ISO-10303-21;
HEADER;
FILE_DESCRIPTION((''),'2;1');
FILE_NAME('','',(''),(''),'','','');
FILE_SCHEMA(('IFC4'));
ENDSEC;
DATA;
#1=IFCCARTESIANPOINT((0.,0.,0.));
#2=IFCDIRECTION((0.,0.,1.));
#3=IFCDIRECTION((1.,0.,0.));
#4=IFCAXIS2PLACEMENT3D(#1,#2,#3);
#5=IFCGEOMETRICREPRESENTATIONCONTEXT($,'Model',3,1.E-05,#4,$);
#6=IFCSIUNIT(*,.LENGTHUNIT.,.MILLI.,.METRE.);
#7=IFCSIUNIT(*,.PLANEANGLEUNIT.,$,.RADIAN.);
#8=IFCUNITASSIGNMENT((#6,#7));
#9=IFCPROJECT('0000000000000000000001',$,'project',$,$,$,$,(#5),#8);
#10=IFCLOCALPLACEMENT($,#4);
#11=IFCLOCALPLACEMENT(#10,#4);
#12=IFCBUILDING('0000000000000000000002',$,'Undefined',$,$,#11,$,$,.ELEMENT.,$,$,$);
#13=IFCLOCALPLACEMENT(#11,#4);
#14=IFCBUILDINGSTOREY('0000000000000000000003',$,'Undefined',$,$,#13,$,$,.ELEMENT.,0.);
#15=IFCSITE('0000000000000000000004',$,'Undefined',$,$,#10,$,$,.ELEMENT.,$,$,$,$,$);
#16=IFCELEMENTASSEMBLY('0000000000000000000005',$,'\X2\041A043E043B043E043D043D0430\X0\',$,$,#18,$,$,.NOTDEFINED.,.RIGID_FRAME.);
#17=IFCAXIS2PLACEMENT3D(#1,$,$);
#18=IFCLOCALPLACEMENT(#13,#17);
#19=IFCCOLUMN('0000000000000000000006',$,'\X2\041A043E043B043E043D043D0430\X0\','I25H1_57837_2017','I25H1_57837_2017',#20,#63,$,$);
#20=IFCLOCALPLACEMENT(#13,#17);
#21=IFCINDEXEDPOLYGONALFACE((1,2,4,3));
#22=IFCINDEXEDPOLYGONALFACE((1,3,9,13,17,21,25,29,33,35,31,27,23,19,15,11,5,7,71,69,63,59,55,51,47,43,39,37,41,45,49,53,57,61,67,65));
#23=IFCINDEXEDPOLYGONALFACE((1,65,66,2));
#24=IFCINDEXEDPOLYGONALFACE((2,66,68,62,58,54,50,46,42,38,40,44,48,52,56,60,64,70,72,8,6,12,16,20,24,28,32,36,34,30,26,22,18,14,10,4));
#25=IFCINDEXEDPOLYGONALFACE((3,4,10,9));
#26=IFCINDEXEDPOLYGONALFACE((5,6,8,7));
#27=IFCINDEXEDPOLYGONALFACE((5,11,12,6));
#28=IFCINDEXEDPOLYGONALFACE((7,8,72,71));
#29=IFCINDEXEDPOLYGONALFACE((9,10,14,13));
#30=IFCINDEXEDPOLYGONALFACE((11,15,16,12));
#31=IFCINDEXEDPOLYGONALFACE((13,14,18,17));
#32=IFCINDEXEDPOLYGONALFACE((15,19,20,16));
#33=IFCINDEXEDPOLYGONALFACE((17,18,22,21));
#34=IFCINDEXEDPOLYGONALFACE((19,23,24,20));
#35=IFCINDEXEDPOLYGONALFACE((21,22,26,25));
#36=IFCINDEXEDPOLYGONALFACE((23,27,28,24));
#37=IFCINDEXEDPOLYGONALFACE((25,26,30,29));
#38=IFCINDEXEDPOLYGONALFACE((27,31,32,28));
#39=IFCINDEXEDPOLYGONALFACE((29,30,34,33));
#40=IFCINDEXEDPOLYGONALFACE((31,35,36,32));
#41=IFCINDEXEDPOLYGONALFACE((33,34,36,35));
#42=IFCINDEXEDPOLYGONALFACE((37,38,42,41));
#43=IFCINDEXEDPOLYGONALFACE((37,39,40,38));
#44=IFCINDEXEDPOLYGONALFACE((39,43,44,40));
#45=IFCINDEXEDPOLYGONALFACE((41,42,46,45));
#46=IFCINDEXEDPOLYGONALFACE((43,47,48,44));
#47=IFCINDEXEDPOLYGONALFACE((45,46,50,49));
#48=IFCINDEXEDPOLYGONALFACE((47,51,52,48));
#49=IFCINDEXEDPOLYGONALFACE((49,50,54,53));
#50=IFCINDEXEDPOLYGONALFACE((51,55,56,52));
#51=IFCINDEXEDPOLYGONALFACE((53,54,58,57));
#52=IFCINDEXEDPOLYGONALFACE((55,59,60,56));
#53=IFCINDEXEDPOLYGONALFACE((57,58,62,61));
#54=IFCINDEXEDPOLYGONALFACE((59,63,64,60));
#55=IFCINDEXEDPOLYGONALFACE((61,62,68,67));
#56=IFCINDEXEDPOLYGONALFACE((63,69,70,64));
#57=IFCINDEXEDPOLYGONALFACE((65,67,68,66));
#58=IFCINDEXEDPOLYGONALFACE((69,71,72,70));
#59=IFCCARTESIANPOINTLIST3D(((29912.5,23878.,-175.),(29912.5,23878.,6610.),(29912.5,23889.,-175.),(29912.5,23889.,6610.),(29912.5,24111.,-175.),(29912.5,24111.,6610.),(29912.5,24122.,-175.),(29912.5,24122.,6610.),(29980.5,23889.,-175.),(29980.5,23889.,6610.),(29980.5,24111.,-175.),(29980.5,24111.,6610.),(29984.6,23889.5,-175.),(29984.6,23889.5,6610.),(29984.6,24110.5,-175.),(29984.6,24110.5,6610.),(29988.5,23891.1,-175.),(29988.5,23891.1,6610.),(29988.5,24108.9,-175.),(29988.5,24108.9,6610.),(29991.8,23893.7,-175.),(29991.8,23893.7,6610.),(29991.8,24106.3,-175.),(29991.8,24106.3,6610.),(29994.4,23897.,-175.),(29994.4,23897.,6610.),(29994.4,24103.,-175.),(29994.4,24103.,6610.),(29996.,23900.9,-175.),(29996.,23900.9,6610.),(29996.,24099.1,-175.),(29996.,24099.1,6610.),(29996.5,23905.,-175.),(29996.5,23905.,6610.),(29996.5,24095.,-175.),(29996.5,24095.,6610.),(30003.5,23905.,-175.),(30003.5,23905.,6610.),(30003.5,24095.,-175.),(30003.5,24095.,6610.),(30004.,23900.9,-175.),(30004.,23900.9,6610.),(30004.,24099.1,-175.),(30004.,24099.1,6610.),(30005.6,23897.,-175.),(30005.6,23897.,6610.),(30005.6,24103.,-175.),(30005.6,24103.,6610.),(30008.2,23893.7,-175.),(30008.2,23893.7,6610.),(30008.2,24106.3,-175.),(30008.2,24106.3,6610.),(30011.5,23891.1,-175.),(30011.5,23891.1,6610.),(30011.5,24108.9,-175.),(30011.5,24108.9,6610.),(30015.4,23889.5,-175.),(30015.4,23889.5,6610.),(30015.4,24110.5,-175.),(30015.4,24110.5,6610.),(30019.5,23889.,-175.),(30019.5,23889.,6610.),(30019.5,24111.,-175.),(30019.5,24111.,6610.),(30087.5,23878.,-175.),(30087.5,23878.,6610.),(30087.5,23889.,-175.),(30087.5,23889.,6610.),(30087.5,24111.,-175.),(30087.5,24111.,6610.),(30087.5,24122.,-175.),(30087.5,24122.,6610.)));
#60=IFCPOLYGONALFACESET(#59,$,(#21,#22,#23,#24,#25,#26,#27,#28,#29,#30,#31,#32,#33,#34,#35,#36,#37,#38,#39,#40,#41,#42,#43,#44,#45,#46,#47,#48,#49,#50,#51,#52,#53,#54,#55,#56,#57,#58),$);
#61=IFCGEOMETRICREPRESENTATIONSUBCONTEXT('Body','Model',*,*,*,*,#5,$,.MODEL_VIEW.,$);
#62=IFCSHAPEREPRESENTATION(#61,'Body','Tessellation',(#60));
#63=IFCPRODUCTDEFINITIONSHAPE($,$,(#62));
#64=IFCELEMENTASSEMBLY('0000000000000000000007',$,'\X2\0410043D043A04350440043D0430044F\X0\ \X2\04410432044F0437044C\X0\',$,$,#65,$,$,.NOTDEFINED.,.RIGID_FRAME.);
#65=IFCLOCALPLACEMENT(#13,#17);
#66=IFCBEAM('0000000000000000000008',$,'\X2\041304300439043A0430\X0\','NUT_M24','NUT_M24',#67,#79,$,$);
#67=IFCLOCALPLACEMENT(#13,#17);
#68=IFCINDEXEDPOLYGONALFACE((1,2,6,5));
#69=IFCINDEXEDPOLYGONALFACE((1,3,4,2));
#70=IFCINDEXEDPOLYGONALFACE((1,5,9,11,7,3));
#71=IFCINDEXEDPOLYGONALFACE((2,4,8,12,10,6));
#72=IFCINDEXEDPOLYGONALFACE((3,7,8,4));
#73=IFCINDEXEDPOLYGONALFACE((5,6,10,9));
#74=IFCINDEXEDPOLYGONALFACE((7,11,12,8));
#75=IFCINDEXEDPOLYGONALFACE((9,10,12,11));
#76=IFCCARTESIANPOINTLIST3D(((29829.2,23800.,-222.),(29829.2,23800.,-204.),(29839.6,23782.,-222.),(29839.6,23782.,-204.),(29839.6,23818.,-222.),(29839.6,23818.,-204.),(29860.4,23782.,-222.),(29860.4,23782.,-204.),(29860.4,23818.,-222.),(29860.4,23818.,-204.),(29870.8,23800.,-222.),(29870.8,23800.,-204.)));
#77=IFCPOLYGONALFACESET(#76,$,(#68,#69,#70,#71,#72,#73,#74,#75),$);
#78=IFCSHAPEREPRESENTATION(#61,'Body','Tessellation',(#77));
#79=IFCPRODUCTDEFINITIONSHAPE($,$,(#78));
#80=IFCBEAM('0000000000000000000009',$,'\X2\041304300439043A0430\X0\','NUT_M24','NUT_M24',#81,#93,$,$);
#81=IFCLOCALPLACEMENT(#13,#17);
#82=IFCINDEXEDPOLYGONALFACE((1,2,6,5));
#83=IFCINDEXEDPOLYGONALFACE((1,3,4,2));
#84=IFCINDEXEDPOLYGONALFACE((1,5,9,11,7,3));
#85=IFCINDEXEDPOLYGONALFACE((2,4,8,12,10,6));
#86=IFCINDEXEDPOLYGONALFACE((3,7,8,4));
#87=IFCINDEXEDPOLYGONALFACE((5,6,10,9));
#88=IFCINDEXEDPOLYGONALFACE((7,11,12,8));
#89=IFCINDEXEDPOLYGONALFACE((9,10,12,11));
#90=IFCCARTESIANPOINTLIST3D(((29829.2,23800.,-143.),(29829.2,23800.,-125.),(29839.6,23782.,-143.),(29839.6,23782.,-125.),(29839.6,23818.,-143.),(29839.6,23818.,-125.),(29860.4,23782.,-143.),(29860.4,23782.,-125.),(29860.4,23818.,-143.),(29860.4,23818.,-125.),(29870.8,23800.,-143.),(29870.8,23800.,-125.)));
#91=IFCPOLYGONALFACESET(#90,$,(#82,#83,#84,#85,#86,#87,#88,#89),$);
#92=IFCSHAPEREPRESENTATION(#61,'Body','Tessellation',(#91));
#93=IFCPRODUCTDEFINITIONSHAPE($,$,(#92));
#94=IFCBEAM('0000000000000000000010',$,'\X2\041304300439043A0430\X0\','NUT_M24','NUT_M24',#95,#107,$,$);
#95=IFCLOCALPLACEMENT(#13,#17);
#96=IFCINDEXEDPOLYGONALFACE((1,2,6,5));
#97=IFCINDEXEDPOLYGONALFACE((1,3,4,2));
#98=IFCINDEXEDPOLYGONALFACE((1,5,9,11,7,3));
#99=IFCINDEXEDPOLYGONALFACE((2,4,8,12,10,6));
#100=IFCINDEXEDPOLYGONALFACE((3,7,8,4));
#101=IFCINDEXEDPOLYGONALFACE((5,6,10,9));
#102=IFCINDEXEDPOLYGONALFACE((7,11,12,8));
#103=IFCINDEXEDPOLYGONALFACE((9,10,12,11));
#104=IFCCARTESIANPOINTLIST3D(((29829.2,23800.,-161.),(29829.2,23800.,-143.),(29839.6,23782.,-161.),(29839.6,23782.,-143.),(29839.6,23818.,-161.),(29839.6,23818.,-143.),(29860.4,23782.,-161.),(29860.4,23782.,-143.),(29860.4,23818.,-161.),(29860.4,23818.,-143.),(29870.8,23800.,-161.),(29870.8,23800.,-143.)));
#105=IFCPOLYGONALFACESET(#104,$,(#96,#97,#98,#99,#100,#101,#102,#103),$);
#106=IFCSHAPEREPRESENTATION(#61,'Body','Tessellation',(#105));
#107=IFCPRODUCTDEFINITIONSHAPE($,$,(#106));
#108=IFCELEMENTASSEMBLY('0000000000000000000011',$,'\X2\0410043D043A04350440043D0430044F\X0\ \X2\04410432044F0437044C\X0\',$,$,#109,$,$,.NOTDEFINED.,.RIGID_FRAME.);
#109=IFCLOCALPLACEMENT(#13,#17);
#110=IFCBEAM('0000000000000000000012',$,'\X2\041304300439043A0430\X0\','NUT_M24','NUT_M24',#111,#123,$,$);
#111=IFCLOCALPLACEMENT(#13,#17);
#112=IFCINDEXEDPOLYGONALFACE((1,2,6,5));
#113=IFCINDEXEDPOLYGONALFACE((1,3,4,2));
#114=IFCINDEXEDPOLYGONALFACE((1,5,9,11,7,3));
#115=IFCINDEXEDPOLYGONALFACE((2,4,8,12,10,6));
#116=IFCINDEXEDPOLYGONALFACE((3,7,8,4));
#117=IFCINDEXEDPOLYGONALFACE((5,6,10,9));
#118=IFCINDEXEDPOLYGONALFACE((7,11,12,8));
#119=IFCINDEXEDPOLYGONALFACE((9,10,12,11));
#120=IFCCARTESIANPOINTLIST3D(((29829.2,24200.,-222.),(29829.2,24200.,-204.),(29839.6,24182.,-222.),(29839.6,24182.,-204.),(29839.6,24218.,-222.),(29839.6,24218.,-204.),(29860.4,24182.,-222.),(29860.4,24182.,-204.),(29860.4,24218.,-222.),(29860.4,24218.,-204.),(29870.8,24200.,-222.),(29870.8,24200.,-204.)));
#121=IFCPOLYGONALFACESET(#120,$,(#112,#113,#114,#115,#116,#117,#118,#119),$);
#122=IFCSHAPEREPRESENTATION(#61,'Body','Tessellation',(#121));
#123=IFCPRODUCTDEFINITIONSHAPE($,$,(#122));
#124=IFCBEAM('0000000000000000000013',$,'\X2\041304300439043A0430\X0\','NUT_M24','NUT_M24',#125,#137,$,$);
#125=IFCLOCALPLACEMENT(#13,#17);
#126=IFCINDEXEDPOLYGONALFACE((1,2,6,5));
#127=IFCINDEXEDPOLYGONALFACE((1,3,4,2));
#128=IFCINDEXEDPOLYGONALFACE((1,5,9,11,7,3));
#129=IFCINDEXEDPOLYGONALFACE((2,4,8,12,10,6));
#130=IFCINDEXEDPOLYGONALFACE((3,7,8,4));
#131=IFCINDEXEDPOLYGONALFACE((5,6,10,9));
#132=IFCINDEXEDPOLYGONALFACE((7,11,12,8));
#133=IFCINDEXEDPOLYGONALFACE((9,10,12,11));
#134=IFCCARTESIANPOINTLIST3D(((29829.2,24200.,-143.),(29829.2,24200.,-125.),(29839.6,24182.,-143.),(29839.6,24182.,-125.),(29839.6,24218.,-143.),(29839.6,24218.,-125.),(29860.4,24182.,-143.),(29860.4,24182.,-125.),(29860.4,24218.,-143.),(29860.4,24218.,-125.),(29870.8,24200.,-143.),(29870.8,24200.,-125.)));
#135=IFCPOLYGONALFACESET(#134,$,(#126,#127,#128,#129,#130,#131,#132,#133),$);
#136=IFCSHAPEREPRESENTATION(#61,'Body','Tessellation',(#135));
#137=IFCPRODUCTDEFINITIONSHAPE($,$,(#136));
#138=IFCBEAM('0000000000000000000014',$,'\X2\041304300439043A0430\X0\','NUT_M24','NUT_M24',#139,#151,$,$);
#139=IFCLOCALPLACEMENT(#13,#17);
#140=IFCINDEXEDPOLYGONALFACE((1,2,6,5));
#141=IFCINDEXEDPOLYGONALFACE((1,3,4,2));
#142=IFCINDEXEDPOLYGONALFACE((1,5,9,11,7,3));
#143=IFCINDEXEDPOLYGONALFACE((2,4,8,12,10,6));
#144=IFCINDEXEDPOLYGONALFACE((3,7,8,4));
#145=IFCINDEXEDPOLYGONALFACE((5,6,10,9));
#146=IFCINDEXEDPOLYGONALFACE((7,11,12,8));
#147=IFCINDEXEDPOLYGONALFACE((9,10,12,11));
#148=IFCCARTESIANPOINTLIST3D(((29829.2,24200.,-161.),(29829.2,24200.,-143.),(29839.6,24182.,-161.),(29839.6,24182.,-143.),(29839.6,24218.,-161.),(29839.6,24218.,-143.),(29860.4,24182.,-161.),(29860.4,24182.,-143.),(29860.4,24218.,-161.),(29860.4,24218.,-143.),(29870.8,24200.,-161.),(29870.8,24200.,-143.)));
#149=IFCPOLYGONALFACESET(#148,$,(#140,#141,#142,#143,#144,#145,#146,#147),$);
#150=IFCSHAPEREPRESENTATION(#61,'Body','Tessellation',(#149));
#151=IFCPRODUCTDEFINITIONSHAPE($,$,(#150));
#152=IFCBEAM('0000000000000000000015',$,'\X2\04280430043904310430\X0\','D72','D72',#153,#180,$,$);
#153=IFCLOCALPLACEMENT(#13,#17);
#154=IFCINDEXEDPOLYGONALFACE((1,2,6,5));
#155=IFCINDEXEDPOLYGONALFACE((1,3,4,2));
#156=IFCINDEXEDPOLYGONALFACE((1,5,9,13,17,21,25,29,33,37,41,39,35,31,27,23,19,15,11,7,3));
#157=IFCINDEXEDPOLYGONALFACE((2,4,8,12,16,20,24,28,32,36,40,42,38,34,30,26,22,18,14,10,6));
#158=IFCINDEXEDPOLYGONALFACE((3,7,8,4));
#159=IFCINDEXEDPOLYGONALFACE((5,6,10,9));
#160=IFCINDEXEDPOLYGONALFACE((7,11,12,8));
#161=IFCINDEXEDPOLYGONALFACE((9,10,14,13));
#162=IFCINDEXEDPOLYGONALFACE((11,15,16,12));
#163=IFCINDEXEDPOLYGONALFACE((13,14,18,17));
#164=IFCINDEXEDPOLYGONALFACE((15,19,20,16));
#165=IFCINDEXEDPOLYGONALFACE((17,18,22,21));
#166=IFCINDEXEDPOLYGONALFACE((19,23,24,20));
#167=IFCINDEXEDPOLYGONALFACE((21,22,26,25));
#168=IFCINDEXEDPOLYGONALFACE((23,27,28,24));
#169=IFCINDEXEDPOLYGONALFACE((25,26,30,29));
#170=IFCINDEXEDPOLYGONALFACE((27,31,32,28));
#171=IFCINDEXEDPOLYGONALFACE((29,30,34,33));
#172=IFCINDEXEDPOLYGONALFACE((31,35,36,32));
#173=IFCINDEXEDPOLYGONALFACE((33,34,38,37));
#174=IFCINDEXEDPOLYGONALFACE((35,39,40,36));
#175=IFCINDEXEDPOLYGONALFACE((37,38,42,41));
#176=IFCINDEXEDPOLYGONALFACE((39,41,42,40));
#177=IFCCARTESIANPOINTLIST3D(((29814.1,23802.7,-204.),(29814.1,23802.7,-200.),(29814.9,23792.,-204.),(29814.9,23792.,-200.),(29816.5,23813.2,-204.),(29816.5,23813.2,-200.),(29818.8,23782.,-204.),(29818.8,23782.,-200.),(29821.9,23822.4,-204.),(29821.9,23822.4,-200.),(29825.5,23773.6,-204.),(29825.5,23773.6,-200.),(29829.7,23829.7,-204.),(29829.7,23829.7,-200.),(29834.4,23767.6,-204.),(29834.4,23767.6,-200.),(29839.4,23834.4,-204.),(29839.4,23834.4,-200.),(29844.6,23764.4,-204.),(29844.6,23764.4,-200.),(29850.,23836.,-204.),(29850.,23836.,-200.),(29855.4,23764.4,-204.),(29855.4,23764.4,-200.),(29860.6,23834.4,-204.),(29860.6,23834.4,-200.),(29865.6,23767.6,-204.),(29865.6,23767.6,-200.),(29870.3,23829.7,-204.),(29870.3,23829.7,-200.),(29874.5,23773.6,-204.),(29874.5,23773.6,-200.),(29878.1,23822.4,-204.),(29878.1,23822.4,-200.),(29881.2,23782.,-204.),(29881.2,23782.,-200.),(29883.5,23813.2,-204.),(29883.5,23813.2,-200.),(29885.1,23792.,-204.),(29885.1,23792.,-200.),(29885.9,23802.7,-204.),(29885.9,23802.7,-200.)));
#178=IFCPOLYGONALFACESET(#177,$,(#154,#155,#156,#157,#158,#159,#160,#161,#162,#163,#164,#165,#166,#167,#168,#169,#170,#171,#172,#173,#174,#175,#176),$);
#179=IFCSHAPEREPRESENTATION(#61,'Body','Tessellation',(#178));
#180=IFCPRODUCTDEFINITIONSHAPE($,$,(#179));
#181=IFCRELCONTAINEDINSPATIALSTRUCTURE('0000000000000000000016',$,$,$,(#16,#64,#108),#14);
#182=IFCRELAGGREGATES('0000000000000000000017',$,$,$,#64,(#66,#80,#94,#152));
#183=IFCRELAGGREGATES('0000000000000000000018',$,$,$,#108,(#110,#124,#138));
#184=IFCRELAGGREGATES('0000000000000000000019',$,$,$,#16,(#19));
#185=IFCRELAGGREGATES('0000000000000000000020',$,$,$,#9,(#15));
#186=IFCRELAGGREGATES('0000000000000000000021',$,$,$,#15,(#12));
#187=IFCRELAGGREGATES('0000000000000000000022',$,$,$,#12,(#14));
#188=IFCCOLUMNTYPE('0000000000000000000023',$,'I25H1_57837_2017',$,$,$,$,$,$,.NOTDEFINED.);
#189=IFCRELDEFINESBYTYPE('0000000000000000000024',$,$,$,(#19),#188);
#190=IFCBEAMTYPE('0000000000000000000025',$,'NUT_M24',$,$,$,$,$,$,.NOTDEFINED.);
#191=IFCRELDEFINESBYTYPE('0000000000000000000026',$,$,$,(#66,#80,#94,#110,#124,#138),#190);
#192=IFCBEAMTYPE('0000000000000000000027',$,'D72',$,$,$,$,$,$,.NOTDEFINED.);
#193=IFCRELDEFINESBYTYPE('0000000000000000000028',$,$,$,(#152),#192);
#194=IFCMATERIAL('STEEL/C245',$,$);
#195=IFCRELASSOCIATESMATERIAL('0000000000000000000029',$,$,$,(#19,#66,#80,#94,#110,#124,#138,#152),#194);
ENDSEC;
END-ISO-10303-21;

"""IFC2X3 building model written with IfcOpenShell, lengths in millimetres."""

from ifc_helpers import new_model, si_unit, frame, origin_with_axes, origin_2d_with_axis, place, context, subcontext, project, spatial, polyline, circle, i_section, outline, extrude, clip, halfspace, material, type_object, element, aggregate, save


model = new_model("IFC2X3")

# Units and contexts
model_context = context("Model", 3, precision=1e-05, world=origin_with_axes())
body_context = subcontext(model_context, "Body", "Model", "MODEL_VIEW")
ifc_project = project(units=[si_unit("LENGTHUNIT", "METRE", prefix="MILLI"), si_unit("PLANEANGLEUNIT", "RADIAN")], contexts=[model_context])

# Site, building, storey
site_placement = place(None, origin_with_axes())
site = spatial("IfcSite", under=ifc_project, at=site_placement, Name="Undefined", CompositionType="ELEMENT")
building_placement = place(site_placement, origin_with_axes())
building = spatial("IfcBuilding", under=site, at=building_placement, Name="Undefined", CompositionType="ELEMENT")
storey_placement = place(building_placement, origin_with_axes())
storey = spatial("IfcBuildingStorey", under=building, at=storey_placement, Name="Undefined", CompositionType="ELEMENT", Elevation=0.0)

# Element assembly, column
ifc_material_1 = material(Name="STEEL/C245")
assembly_1_placement = place(storey_placement, origin_with_axes())
assembly_1 = element("IfcElementAssembly", 1, at=assembly_1_placement, inside=storey, Name="Колонна", AssemblyPlace="NOTDEFINED", PredefinedType="RIGID_FRAME")
column_type_1 = type_object("IfcColumnType", Name="I25H1_57837_2017", PredefinedType="NOTDEFINED")
column_1_placement = place(assembly_1_placement, frame((30000.0, 24000.0, 0.0), z_axis=(0.0, 0.0, 1.0), x_axis=(0.0, 1.0, 0.0)))
column_1 = element("IfcColumn", 2, at=column_1_placement, type_object=column_type_1, material=ifc_material_1, Name="Колонна", Description="I25H1_57837_2017", ObjectType="I25H1_57837_2017", context=body_context, shape_type="Clipping", body=[
    clip(extrude(i_section(OverallWidth=175.0, OverallDepth=244.0, WebThickness=7.0, FlangeThickness=11.0, FilletRadius=16.0, at=origin_2d_with_axis()), frame((0.0, 0.0, 6610.0), z_axis=(0.0, 0.0, -1.0), x_axis=(0.0, 1.0, 0.0)), (0.0, 0.0, 1.0), 6785.0), halfspace(frame((-122.0, 0.0, -175.0), z_axis=(0.0, 0.0, 1.0), x_axis=(0.0, 1.0, 0.0)), True)),
])

# Element assemblies, beams
assembly_2_placement = place(storey_placement, origin_with_axes())
assembly_2 = element("IfcElementAssembly", 3, at=assembly_2_placement, inside=storey, Name="Анкерная связь", AssemblyPlace="NOTDEFINED", PredefinedType="RIGID_FRAME")
beam_type_1 = type_object("IfcBeamType", Name="NUT_M24", PredefinedType="NOTDEFINED")
beam_1_placement = place(assembly_2_placement, frame((29850.0, 23800.0, -204.0), z_axis=(0.0, -1.0, 0.0), x_axis=(0.0, 0.0, -1.0)))
beam_1 = element("IfcBeam", 4, at=beam_1_placement, type_object=beam_type_1, material=ifc_material_1, Name="Гайка", Description="NUT_M24", ObjectType="NUT_M24", context=body_context, shape_type="SweptSolid", body=[
    extrude(outline(polyline([(-10.4, 18.0), (10.4, 18.0), (20.8, 0.0), (10.4, -18.0), (-10.4, -18.0), (-20.8, 0.0), (-10.4, 18.0)])), frame((18.0, 0.0, 0.0), z_axis=(-1.0, 0.0, 0.0), x_axis=(0.0, -1.0, 0.0)), (0.0, 0.0, 1.0), 18.0),
])
beam_2_placement = place(assembly_2_placement, frame((29850.0, 23800.0, -125.0), z_axis=(0.0, -1.0, 0.0), x_axis=(0.0, 0.0, -1.0)))
beam_2 = element("IfcBeam", 5, at=beam_2_placement, type_object=beam_type_1, material=ifc_material_1, Name="Гайка", Description="NUT_M24", ObjectType="NUT_M24", context=body_context, shape_type="SweptSolid", body=[
    extrude(outline(polyline([(-10.4, 18.0), (10.4, 18.0), (20.8, 0.0), (10.4, -18.0), (-10.4, -18.0), (-20.8, 0.0), (-10.4, 18.0)])), frame((18.0, 0.0, 0.0), z_axis=(-1.0, 0.0, 0.0), x_axis=(0.0, -1.0, 0.0)), (0.0, 0.0, 1.0), 18.0),
])
beam_3_placement = place(assembly_2_placement, frame((29850.0, 23800.0, -143.0), z_axis=(0.0, -1.0, 0.0), x_axis=(0.0, 0.0, -1.0)))
beam_3 = element("IfcBeam", 6, at=beam_3_placement, type_object=beam_type_1, material=ifc_material_1, Name="Гайка", Description="NUT_M24", ObjectType="NUT_M24", context=body_context, shape_type="SweptSolid", body=[
    extrude(outline(polyline([(-10.4, 18.0), (10.4, 18.0), (20.8, 0.0), (10.4, -18.0), (-10.4, -18.0), (-20.8, 0.0), (-10.4, 18.0)])), frame((18.0, 0.0, 0.0), z_axis=(-1.0, 0.0, 0.0), x_axis=(0.0, -1.0, 0.0)), (0.0, 0.0, 1.0), 18.0),
])
assembly_3_placement = place(storey_placement, origin_with_axes())
assembly_3 = element("IfcElementAssembly", 7, at=assembly_3_placement, inside=storey, Name="Анкерная связь", AssemblyPlace="NOTDEFINED", PredefinedType="RIGID_FRAME")
beam_4_placement = place(assembly_3_placement, frame((29850.0, 24200.0, -204.0), z_axis=(0.0, -1.0, 0.0), x_axis=(0.0, 0.0, -1.0)))
beam_4 = element("IfcBeam", 8, at=beam_4_placement, type_object=beam_type_1, material=ifc_material_1, Name="Гайка", Description="NUT_M24", ObjectType="NUT_M24", context=body_context, shape_type="SweptSolid", body=[
    extrude(outline(polyline([(-10.4, 18.0), (10.4, 18.0), (20.8, 0.0), (10.4, -18.0), (-10.4, -18.0), (-20.8, 0.0), (-10.4, 18.0)])), frame((18.0, 0.0, 0.0), z_axis=(-1.0, 0.0, 0.0), x_axis=(0.0, -1.0, 0.0)), (0.0, 0.0, 1.0), 18.0),
])
beam_5_placement = place(assembly_3_placement, frame((29850.0, 24200.0, -125.0), z_axis=(0.0, -1.0, 0.0), x_axis=(0.0, 0.0, -1.0)))
beam_5 = element("IfcBeam", 9, at=beam_5_placement, type_object=beam_type_1, material=ifc_material_1, Name="Гайка", Description="NUT_M24", ObjectType="NUT_M24", context=body_context, shape_type="SweptSolid", body=[
    extrude(outline(polyline([(-10.4, 18.0), (10.4, 18.0), (20.8, 0.0), (10.4, -18.0), (-10.4, -18.0), (-20.8, 0.0), (-10.4, 18.0)])), frame((18.0, 0.0, 0.0), z_axis=(-1.0, 0.0, 0.0), x_axis=(0.0, -1.0, 0.0)), (0.0, 0.0, 1.0), 18.0),
])
beam_6_placement = place(assembly_3_placement, frame((29850.0, 24200.0, -143.0), z_axis=(0.0, -1.0, 0.0), x_axis=(0.0, 0.0, -1.0)))
beam_6 = element("IfcBeam", 10, at=beam_6_placement, type_object=beam_type_1, material=ifc_material_1, Name="Гайка", Description="NUT_M24", ObjectType="NUT_M24", context=body_context, shape_type="SweptSolid", body=[
    extrude(outline(polyline([(-10.4, 18.0), (10.4, 18.0), (20.8, 0.0), (10.4, -18.0), (-10.4, -18.0), (-20.8, 0.0), (-10.4, 18.0)])), frame((18.0, 0.0, 0.0), z_axis=(-1.0, 0.0, 0.0), x_axis=(0.0, -1.0, 0.0)), (0.0, 0.0, 1.0), 18.0),
])

# Beam
beam_type_2 = type_object("IfcBeamType", Name="D72", PredefinedType="NOTDEFINED")
beam_7_placement = place(assembly_2_placement, frame((29850.0, 23800.0, -200.0), z_axis=(-1.0, 0.0, 0.0), x_axis=(0.0, 0.0, -1.0)))
beam_7 = element("IfcBeam", 11, at=beam_7_placement, type_object=beam_type_2, material=ifc_material_1, Name="Шайба", Description="D72", ObjectType="D72", context=body_context, shape_type="SweptSolid", body=[
    extrude(circle(Radius=36.0, at=origin_2d_with_axis()), frame((4.0, 0.0, 0.0), z_axis=(-1.0, 0.0, 0.0), x_axis=(0.0, -1.0, 0.0)), (0.0, 0.0, 1.0), 4.0),
])

aggregate(assembly_2, [beam_1, beam_2, beam_3, beam_7])
aggregate(assembly_3, [beam_4, beam_5, beam_6])
aggregate(assembly_1, [column_1])

save(model, "model.ifc")
